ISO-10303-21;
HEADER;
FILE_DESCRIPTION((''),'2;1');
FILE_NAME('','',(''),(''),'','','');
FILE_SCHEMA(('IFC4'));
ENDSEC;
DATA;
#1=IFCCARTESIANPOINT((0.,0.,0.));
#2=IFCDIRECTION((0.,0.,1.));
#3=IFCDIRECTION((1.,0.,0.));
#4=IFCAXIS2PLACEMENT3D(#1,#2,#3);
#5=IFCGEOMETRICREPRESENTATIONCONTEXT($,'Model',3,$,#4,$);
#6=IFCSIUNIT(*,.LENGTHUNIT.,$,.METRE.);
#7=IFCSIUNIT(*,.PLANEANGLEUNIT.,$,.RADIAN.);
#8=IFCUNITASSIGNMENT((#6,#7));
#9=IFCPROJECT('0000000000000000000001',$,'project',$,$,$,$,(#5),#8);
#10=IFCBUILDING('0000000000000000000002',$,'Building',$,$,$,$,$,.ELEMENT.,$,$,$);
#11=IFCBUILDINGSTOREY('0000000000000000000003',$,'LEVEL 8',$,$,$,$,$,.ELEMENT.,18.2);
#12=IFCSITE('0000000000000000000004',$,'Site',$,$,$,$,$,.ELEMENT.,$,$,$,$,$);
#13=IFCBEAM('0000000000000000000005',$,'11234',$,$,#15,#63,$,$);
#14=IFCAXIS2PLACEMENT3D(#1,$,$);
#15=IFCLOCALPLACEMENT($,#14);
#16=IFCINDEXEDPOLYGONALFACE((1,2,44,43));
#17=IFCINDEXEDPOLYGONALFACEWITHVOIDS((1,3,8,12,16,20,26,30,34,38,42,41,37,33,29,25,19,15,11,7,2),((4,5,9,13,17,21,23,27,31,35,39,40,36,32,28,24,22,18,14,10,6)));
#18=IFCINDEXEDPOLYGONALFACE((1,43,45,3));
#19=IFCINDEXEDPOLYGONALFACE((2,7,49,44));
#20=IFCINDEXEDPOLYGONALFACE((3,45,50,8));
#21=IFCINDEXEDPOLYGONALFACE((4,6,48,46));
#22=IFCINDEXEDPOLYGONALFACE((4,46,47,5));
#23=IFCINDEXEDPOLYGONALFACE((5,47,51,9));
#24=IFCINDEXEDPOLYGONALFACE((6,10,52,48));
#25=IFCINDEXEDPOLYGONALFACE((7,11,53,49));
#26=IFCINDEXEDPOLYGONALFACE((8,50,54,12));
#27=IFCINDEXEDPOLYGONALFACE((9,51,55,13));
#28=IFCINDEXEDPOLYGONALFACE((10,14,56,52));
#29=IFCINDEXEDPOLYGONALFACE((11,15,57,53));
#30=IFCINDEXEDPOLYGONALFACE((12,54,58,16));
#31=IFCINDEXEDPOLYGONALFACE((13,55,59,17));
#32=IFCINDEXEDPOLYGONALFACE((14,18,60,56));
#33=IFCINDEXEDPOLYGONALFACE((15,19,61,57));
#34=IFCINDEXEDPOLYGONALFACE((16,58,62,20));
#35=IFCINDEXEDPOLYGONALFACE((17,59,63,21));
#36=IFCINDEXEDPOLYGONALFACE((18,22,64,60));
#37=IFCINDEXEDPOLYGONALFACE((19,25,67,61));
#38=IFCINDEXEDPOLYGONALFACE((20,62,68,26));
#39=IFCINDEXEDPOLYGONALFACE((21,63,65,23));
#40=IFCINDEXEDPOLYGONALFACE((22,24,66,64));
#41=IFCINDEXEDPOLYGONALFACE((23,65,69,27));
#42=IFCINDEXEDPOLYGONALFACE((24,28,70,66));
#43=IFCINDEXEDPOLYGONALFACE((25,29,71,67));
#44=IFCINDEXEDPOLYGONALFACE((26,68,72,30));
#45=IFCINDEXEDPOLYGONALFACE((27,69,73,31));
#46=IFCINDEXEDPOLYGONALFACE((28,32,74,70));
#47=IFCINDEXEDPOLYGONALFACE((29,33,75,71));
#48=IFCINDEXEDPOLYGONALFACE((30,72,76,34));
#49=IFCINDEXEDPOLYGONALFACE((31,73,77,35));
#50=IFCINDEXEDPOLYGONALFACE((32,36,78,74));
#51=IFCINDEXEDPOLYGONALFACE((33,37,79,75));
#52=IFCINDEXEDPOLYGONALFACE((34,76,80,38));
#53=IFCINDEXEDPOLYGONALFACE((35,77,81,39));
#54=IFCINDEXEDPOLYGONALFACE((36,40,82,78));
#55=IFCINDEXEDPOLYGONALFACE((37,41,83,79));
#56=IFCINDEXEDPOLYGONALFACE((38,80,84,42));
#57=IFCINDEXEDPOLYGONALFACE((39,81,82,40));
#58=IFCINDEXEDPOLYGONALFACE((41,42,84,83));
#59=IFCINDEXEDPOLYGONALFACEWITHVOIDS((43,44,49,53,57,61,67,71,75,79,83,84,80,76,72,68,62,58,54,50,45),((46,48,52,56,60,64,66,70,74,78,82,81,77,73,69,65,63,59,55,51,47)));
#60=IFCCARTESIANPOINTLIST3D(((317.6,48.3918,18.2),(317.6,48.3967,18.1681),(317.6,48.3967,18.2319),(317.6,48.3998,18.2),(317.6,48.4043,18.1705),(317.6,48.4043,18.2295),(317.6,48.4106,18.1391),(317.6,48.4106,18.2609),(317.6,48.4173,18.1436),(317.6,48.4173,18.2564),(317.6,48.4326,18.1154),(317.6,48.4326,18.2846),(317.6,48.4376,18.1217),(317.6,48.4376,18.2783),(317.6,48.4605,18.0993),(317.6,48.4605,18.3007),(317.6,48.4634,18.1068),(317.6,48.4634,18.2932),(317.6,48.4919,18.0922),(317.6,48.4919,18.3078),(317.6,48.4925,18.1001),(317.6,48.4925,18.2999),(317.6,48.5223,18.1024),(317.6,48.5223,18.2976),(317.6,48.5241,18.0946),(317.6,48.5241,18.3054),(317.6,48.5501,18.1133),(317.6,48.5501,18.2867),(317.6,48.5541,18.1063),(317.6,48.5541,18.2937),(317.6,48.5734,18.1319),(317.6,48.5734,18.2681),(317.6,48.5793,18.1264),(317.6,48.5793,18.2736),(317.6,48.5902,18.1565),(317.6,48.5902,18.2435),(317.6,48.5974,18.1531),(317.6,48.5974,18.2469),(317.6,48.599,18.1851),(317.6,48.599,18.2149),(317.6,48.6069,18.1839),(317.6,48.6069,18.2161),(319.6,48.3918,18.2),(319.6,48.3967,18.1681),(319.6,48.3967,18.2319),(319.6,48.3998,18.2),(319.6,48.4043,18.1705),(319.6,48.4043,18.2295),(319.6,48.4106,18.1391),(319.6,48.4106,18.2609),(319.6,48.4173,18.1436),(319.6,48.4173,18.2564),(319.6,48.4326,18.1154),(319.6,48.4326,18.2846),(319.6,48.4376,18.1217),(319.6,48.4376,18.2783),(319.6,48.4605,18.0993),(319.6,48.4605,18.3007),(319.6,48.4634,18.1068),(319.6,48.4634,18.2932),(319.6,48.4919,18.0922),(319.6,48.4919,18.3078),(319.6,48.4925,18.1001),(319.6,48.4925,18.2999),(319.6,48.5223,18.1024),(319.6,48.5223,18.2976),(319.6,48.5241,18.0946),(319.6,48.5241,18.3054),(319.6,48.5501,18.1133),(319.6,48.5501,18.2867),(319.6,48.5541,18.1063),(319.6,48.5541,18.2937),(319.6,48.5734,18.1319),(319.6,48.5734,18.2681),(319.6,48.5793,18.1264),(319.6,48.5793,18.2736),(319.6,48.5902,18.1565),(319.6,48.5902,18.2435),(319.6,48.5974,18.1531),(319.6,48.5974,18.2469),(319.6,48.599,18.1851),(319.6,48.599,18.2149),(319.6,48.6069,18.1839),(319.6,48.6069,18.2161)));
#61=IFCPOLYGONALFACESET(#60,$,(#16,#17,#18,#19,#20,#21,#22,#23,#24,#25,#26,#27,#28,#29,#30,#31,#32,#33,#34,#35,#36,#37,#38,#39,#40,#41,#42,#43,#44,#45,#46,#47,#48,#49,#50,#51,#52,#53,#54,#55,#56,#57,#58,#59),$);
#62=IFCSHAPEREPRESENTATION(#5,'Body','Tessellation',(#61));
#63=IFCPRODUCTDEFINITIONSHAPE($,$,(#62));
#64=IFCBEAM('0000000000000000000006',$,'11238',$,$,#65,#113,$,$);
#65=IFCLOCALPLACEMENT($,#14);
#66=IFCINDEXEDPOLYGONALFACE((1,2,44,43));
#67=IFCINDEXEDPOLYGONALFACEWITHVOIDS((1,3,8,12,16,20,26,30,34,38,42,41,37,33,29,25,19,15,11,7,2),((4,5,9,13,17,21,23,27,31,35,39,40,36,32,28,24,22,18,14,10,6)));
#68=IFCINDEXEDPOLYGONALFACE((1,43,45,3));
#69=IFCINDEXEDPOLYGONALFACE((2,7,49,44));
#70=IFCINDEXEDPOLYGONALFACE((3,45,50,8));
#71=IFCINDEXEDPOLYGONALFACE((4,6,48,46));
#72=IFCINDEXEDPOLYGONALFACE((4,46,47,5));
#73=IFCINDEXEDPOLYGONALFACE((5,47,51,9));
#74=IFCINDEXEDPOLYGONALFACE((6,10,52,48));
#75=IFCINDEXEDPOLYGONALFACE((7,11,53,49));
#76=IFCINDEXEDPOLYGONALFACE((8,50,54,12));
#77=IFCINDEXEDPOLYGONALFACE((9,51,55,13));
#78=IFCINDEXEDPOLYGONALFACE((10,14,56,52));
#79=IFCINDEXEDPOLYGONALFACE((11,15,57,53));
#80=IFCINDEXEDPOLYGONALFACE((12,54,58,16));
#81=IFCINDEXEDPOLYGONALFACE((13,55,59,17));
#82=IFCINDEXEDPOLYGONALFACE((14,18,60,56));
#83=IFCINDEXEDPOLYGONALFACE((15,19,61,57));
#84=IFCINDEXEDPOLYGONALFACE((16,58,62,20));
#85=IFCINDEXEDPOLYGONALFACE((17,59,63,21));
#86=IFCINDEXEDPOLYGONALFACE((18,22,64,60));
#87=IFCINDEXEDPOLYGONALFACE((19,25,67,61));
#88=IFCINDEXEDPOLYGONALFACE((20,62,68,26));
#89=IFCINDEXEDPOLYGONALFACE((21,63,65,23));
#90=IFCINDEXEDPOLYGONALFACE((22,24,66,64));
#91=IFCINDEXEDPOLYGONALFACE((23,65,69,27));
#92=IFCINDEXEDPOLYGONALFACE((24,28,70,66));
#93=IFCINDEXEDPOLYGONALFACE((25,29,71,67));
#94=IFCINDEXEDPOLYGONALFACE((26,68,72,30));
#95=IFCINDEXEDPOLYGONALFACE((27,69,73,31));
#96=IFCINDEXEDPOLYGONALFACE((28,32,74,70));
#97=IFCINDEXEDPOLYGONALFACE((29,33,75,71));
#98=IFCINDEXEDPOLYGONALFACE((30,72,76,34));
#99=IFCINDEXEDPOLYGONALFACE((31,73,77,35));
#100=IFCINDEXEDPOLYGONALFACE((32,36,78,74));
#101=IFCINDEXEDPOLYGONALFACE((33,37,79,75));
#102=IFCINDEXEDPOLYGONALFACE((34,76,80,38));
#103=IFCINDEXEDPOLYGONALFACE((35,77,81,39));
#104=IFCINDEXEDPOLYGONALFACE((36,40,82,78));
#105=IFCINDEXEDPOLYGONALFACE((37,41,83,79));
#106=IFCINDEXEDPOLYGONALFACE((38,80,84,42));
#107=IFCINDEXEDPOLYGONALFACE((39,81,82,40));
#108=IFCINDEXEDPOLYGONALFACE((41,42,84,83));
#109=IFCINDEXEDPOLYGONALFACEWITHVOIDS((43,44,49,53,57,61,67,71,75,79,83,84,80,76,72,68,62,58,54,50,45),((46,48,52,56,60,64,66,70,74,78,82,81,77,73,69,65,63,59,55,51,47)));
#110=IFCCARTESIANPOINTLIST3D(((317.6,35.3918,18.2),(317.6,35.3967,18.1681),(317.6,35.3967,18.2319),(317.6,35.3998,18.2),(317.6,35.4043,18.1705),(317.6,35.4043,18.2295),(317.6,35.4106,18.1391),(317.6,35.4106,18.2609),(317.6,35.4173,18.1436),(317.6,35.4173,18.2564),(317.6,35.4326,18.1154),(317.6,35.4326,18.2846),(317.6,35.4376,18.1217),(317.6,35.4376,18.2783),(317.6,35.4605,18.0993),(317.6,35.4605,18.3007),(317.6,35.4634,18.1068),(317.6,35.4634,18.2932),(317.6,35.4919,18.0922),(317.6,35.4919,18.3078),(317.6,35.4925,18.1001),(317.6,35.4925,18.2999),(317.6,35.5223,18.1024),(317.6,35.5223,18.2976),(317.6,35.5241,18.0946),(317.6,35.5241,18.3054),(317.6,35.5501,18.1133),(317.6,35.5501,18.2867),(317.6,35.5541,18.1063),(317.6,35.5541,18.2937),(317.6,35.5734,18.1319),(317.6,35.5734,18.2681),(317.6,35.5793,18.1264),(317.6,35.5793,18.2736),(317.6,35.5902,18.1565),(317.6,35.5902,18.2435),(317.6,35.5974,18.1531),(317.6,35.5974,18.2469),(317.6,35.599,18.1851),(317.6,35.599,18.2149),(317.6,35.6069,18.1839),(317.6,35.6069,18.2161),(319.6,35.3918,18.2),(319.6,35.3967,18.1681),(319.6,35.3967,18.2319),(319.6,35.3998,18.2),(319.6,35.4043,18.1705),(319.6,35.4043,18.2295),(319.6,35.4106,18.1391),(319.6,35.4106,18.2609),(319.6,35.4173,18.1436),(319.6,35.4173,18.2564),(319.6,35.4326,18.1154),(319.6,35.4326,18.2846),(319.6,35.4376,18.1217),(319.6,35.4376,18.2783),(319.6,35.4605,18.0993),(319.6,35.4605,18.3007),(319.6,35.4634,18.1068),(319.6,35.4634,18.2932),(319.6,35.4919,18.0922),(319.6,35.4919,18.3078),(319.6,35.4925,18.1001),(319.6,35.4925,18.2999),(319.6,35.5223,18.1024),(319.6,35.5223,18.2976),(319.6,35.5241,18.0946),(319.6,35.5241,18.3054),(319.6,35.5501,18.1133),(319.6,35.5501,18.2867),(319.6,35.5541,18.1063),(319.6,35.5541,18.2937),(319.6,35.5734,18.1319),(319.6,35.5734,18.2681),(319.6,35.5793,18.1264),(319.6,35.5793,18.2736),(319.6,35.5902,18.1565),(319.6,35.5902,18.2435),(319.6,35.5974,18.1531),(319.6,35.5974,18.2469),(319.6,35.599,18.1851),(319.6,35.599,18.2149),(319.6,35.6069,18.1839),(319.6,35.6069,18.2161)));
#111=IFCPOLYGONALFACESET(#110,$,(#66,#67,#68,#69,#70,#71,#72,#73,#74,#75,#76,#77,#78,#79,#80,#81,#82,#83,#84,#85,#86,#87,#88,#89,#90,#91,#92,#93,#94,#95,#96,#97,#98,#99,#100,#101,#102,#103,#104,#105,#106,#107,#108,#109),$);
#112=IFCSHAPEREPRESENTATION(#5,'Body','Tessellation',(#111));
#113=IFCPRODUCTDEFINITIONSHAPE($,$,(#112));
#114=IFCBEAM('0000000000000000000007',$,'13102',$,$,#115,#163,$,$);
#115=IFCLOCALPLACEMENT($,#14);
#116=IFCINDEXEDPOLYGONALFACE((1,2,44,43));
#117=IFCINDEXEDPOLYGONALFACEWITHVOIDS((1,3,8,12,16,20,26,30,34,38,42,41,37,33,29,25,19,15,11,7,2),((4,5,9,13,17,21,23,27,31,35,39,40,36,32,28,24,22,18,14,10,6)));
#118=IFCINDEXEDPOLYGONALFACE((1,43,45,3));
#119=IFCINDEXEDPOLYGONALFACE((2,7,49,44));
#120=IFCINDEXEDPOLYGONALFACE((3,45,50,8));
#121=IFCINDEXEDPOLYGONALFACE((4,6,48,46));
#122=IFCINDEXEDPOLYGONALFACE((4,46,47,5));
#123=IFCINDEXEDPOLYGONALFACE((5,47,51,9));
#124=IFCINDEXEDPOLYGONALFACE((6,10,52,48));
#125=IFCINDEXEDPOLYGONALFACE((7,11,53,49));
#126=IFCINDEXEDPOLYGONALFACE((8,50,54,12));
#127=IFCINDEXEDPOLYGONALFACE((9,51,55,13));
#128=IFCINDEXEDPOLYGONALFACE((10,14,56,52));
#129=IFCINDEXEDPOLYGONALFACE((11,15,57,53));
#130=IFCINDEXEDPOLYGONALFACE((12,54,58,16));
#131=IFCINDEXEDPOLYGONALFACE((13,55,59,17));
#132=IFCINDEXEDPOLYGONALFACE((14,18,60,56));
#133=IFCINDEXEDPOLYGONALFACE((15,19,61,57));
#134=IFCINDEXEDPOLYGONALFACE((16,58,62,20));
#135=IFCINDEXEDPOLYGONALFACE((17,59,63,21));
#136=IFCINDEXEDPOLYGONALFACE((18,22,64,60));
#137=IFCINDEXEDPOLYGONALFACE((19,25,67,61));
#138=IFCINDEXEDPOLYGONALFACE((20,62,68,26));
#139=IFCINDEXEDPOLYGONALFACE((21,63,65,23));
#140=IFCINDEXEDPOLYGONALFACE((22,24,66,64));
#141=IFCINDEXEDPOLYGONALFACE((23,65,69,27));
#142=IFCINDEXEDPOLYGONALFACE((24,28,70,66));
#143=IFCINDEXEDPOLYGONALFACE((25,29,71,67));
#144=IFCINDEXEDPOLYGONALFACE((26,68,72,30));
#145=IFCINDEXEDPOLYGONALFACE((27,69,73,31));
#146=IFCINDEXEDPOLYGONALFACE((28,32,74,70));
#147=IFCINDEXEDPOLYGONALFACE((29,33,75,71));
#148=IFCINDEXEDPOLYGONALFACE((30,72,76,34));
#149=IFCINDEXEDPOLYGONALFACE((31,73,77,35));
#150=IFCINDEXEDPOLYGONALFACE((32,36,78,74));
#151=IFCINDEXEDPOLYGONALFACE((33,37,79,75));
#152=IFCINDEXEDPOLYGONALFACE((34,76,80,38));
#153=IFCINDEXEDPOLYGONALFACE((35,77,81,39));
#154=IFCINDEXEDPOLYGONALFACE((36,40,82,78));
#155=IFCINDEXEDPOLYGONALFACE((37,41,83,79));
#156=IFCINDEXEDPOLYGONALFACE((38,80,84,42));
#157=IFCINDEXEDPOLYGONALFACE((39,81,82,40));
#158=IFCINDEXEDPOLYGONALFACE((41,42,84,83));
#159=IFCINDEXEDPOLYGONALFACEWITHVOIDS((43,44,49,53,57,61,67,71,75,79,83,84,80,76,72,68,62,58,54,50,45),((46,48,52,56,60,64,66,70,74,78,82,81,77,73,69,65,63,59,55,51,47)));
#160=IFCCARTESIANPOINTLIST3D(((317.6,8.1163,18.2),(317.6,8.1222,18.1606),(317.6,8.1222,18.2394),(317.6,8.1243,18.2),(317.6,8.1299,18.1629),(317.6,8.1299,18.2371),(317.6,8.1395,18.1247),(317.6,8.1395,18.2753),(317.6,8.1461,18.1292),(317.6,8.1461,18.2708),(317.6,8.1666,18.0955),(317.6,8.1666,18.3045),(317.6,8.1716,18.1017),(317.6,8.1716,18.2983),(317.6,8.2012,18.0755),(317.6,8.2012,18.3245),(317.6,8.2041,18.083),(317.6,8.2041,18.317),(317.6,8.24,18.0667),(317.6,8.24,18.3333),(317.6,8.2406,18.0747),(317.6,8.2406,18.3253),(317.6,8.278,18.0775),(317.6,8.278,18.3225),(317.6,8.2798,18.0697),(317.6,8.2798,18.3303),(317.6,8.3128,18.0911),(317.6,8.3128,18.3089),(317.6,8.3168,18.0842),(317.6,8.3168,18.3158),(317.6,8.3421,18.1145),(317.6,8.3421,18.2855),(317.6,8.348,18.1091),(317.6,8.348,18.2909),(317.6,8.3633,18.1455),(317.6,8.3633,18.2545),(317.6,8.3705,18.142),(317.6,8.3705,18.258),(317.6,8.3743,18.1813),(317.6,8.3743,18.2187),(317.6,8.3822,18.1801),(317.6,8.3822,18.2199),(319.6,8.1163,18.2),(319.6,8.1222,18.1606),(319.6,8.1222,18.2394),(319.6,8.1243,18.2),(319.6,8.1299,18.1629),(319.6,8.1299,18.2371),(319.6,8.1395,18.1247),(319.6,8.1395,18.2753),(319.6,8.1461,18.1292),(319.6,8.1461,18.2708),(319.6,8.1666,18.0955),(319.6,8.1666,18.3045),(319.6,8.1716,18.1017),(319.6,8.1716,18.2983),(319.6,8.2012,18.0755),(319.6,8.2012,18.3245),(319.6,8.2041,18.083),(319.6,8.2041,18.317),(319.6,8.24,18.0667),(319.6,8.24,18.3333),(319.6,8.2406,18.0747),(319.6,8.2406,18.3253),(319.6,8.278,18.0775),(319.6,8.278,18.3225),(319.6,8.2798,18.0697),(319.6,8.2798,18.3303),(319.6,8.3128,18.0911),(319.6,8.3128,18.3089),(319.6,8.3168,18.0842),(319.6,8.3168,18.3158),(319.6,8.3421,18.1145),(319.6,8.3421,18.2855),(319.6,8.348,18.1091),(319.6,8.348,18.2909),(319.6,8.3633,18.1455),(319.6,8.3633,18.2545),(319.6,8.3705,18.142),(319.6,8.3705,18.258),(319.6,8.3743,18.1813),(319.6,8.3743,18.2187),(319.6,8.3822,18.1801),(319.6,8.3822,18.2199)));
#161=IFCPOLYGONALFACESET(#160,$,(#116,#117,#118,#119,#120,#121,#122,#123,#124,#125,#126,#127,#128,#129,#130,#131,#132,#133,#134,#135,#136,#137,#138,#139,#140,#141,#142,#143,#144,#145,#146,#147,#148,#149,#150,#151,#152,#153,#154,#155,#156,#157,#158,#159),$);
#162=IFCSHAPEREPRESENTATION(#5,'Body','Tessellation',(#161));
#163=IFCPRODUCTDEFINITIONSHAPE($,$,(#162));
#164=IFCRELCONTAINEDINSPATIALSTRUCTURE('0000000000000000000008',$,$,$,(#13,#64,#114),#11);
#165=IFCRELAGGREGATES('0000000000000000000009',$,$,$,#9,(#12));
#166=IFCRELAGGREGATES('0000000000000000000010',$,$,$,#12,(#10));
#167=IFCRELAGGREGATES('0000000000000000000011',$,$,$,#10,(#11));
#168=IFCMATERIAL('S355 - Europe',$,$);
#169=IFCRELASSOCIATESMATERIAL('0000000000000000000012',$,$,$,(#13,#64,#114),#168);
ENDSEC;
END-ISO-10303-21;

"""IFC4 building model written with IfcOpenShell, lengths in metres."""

from ifc_helpers import new_model, si_unit, frame, origin_with_axes, origin_2d_with_axis, place, context, project, spatial, hollow_circle, extrude, material, material_profile, profile_set, profile_usage, element, save


model = new_model("IFC4")

# Units and contexts
model_context = context("Model", 3, world=origin_with_axes())
ifc_project = project(units=[si_unit("LENGTHUNIT", "METRE"), si_unit("PLANEANGLEUNIT", "RADIAN")], contexts=[model_context])

# Site, building, storey
site = spatial("IfcSite", under=ifc_project, Name="Site", CompositionType="ELEMENT")
building = spatial("IfcBuilding", under=site, Name="Building", CompositionType="ELEMENT")
storey = spatial("IfcBuildingStorey", under=building, Name="LEVEL 8", CompositionType="ELEMENT", Elevation=18.2)

# Shared definitions
ifc_material = material(Name="S355 - Europe")

# Beams
ifc_material_profile_1 = material_profile(ifc_material, hollow_circle(Radius=0.1081, WallThickness=0.008, at=origin_2d_with_axis()))
ifc_profile_set_1 = profile_set([ifc_material_profile_1])
ifc_profile_usage_1 = profile_usage(ifc_profile_set_1, cardinal=10)
beam_1_placement = place(None, frame((319.6, 48.5, 18.2), z_axis=(-1.0, 0.0, 0.0), x_axis=(0.0, -1.0, 0.0)))
element("IfcBeam", 1, at=beam_1_placement, inside=storey, material=ifc_profile_usage_1, Name="11234", context=model_context, shape_type="SweptSolid", body=[
    extrude(hollow_circle(Radius=0.1081, WallThickness=0.008, at=origin_2d_with_axis()), origin_with_axes(), (0.0, 0.0, 1.0), 2.0),
])
ifc_material_profile_2 = material_profile(ifc_material, hollow_circle(Radius=0.1081, WallThickness=0.008, at=origin_2d_with_axis()))
ifc_profile_set_2 = profile_set([ifc_material_profile_2])
ifc_profile_usage_2 = profile_usage(ifc_profile_set_2, cardinal=10)
beam_2_placement = place(None, frame((319.6, 35.5, 18.2), z_axis=(-1.0, 0.0, 0.0), x_axis=(0.0, -1.0, 0.0)))
element("IfcBeam", 2, at=beam_2_placement, inside=storey, material=ifc_profile_usage_2, Name="11238", context=model_context, shape_type="SweptSolid", body=[
    extrude(hollow_circle(Radius=0.1081, WallThickness=0.008, at=origin_2d_with_axis()), origin_with_axes(), (0.0, 0.0, 1.0), 2.0),
])
ifc_material_profile_3 = material_profile(ifc_material, hollow_circle(Radius=0.1337, WallThickness=0.008, at=origin_2d_with_axis()))
ifc_profile_set_3 = profile_set([ifc_material_profile_3])
ifc_profile_usage_3 = profile_usage(ifc_profile_set_3, cardinal=10)
beam_3_placement = place(None, frame((319.6, 8.25, 18.2), z_axis=(-1.0, 0.0, 0.0), x_axis=(0.0, -1.0, 0.0)))
element("IfcBeam", 3, at=beam_3_placement, inside=storey, material=ifc_profile_usage_3, Name="13102", context=model_context, shape_type="SweptSolid", body=[
    extrude(hollow_circle(Radius=0.1337, WallThickness=0.008, at=origin_2d_with_axis()), origin_with_axes(), (0.0, 0.0, 1.0), 2.0),
])

save(model, "model.ifc")
